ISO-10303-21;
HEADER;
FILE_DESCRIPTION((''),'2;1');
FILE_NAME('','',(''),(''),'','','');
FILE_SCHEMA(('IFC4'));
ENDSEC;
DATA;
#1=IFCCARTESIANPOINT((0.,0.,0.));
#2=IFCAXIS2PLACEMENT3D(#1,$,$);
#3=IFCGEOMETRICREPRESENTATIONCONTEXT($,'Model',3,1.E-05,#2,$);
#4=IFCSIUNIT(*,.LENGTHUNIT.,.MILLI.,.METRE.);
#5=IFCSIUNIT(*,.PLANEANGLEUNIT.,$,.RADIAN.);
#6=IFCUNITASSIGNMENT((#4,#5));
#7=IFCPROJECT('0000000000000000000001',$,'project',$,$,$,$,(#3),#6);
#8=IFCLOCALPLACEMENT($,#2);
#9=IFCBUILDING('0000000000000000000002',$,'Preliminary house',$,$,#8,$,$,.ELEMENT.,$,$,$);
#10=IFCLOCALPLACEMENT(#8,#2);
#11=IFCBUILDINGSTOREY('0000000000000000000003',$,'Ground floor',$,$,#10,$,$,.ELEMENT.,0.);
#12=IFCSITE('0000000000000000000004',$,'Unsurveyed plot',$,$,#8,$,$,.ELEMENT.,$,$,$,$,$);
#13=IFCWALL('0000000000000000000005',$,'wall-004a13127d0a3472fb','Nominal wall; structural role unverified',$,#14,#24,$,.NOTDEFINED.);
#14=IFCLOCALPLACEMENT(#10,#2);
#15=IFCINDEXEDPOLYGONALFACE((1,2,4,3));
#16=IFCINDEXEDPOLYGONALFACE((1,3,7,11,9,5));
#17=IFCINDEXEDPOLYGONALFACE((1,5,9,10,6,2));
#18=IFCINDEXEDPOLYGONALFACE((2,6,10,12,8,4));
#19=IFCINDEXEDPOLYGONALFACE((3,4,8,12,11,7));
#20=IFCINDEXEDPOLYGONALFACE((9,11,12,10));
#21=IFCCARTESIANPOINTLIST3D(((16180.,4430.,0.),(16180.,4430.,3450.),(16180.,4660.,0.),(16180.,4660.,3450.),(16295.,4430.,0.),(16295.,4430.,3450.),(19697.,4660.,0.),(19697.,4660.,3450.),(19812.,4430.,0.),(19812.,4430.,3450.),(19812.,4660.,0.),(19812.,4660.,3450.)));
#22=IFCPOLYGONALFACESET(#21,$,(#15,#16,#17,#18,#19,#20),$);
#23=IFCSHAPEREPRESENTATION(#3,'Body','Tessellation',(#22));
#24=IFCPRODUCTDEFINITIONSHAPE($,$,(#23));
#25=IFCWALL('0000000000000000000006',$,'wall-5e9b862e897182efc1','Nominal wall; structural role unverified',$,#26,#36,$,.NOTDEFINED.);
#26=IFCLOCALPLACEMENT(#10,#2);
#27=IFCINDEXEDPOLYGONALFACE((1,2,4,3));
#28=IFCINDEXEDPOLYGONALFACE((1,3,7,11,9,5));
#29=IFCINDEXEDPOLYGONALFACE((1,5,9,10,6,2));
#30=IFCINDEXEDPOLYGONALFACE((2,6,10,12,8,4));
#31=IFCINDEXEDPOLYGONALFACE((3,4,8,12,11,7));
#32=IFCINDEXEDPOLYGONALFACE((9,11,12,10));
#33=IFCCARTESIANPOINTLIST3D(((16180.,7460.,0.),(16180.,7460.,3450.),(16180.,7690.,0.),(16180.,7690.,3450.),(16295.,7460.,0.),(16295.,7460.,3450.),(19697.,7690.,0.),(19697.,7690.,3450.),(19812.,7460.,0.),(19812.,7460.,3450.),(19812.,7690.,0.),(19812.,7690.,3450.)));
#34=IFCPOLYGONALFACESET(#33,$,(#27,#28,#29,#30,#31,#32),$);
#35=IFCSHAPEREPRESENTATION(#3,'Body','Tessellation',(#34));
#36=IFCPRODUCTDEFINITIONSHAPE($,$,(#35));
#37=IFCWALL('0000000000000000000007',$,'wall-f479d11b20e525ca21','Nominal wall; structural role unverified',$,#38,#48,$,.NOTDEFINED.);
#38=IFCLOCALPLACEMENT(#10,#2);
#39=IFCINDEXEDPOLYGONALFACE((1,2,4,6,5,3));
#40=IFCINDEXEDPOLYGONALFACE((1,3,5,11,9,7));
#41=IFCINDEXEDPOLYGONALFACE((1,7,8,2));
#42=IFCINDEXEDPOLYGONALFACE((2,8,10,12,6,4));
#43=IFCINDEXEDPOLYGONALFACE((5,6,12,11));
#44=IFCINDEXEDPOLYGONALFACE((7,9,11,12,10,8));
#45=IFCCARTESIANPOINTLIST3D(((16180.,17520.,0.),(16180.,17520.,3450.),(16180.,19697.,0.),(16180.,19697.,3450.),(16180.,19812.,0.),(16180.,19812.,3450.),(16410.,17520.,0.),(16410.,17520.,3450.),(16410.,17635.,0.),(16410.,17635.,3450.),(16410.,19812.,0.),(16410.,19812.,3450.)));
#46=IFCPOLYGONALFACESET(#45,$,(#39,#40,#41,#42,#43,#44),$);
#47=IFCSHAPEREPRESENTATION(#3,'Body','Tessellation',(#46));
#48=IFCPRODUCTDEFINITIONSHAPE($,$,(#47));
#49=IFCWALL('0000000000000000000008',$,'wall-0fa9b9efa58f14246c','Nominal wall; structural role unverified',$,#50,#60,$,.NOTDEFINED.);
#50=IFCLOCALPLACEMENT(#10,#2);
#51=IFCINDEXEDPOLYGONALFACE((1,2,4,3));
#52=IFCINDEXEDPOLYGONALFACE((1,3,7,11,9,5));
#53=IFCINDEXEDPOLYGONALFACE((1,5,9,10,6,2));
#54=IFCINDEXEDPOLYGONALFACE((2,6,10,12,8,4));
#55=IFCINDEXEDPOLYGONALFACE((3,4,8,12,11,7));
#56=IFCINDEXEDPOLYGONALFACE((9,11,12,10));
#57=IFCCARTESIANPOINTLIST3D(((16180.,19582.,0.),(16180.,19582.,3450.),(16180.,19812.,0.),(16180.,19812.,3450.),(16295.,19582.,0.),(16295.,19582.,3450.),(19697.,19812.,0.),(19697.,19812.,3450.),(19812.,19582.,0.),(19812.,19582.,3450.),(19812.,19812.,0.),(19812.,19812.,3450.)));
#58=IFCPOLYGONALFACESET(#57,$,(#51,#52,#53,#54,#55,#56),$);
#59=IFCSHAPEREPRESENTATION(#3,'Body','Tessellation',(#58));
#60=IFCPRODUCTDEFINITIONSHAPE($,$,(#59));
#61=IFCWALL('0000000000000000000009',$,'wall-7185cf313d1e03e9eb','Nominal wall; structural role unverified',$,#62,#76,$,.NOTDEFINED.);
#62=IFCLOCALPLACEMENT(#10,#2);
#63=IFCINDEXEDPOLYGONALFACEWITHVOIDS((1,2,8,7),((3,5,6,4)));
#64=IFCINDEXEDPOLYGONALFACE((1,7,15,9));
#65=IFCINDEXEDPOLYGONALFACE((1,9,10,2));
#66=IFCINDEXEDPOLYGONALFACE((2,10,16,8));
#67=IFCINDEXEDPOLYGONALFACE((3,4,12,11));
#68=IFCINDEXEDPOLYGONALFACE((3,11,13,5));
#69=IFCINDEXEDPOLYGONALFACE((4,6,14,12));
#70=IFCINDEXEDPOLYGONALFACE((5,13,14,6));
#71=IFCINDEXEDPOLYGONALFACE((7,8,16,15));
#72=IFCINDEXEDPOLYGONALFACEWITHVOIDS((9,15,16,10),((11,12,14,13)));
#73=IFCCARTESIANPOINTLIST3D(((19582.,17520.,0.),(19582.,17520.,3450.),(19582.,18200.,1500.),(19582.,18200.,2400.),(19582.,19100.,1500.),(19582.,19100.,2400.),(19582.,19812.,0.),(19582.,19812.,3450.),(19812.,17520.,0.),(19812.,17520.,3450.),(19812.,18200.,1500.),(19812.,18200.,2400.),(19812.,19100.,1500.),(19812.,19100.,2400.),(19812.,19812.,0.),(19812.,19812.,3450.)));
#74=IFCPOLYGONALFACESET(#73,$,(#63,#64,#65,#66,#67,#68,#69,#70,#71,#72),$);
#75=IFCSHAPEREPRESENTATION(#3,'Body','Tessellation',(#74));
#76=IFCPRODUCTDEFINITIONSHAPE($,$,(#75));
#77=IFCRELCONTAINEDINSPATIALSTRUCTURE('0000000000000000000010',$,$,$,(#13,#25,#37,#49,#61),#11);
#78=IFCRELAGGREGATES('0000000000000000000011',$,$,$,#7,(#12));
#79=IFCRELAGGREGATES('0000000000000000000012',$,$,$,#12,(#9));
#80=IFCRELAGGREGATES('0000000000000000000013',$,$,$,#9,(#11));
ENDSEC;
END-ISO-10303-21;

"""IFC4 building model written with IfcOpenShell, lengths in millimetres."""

from ifc_helpers import new_model, si_unit, frame, origin, place, context, project, spatial, polyline, outline, extrude, element, save


model = new_model("IFC4")

# Units and contexts
model_context = context("Model", 3, precision=1e-05, world=origin())
ifc_project = project(units=[si_unit("LENGTHUNIT", "METRE", prefix="MILLI"), si_unit("PLANEANGLEUNIT", "RADIAN")], contexts=[model_context])

# Site, building, storey
placement_1 = place(None, origin())
site = spatial("IfcSite", under=ifc_project, at=placement_1, Name="Unsurveyed plot", CompositionType="ELEMENT")
building = spatial("IfcBuilding", under=site, at=placement_1, Name="Preliminary house", CompositionType="ELEMENT")
placement_2 = place(placement_1, origin())
storey = spatial("IfcBuildingStorey", under=building, at=placement_2, Name="Ground floor", CompositionType="ELEMENT", Elevation=0.0)

# Walls
element("IfcWall", 1, at=placement_2, inside=storey, Name="wall-004a13127d0a3472fb", Description="Nominal wall; structural role unverified", PredefinedType="NOTDEFINED", context=model_context, shape_type="SweptSolid", body=[
    extrude(outline(polyline([(19697.0, 4660.0), (19812.0, 4660.0), (19812.0, 4430.0), (16295.0, 4430.0), (16180.0, 4430.0), (16180.0, 4660.0), (19697.0, 4660.0)])), origin(), (0.0, 0.0, 1.0), 3450.0),
])
element("IfcWall", 2, at=placement_2, inside=storey, Name="wall-5e9b862e897182efc1", Description="Nominal wall; structural role unverified", PredefinedType="NOTDEFINED", context=model_context, shape_type="SweptSolid", body=[
    extrude(outline(polyline([(19697.0, 7690.0), (19812.0, 7690.0), (19812.0, 7460.0), (16295.0, 7460.0), (16180.0, 7460.0), (16180.0, 7690.0), (19697.0, 7690.0)])), origin(), (0.0, 0.0, 1.0), 3450.0),
])
element("IfcWall", 3, at=placement_2, inside=storey, Name="wall-f479d11b20e525ca21", Description="Nominal wall; structural role unverified", PredefinedType="NOTDEFINED", context=model_context, shape_type="SweptSolid", body=[
    extrude(outline(polyline([(16180.0, 19697.0), (16180.0, 19812.0), (16410.0, 19812.0), (16410.0, 17635.0), (16410.0, 17520.0), (16180.0, 17520.0), (16180.0, 19697.0)])), origin(), (0.0, 0.0, 1.0), 3450.0),
])

# Wall
element("IfcWall", 4, at=placement_2, inside=storey, Name="wall-0fa9b9efa58f14246c", Description="Nominal wall; structural role unverified", PredefinedType="NOTDEFINED", context=model_context, shape_type="SweptSolid", body=[
    extrude(outline(polyline([(19697.0, 19812.0), (19812.0, 19812.0), (19812.0, 19582.0), (16295.0, 19582.0), (16180.0, 19582.0), (16180.0, 19812.0), (19697.0, 19812.0)])), origin(), (0.0, 0.0, 1.0), 3450.0),
])

# Wall, opening
wall_1 = element("IfcWall", 5, at=placement_2, inside=storey, Name="wall-7185cf313d1e03e9eb", Description="Nominal wall; structural role unverified", PredefinedType="NOTDEFINED", context=model_context, shape_type="SweptSolid", body=[
    extrude(outline(polyline([(19582.0, 19697.0), (19582.0, 19812.0), (19812.0, 19812.0), (19812.0, 17635.0), (19812.0, 17520.0), (19582.0, 17520.0), (19582.0, 19697.0)])), origin(), (0.0, 0.0, 1.0), 3450.0),
])
element("IfcOpeningElement", 6, at=placement_2, cuts=wall_1, PredefinedType="OPENING", context=model_context, shape_type="SweptSolid", body=[
    extrude(outline(polyline([(20227.0, 18200.0), (20227.0, 19100.0), (19167.0, 19100.0), (19167.0, 18200.0), (20227.0, 18200.0)])), frame((0.0, 0.0, 1500.0)), (0.0, 0.0, 1.0), 900.0),
])

save(model, "model.ifc")
